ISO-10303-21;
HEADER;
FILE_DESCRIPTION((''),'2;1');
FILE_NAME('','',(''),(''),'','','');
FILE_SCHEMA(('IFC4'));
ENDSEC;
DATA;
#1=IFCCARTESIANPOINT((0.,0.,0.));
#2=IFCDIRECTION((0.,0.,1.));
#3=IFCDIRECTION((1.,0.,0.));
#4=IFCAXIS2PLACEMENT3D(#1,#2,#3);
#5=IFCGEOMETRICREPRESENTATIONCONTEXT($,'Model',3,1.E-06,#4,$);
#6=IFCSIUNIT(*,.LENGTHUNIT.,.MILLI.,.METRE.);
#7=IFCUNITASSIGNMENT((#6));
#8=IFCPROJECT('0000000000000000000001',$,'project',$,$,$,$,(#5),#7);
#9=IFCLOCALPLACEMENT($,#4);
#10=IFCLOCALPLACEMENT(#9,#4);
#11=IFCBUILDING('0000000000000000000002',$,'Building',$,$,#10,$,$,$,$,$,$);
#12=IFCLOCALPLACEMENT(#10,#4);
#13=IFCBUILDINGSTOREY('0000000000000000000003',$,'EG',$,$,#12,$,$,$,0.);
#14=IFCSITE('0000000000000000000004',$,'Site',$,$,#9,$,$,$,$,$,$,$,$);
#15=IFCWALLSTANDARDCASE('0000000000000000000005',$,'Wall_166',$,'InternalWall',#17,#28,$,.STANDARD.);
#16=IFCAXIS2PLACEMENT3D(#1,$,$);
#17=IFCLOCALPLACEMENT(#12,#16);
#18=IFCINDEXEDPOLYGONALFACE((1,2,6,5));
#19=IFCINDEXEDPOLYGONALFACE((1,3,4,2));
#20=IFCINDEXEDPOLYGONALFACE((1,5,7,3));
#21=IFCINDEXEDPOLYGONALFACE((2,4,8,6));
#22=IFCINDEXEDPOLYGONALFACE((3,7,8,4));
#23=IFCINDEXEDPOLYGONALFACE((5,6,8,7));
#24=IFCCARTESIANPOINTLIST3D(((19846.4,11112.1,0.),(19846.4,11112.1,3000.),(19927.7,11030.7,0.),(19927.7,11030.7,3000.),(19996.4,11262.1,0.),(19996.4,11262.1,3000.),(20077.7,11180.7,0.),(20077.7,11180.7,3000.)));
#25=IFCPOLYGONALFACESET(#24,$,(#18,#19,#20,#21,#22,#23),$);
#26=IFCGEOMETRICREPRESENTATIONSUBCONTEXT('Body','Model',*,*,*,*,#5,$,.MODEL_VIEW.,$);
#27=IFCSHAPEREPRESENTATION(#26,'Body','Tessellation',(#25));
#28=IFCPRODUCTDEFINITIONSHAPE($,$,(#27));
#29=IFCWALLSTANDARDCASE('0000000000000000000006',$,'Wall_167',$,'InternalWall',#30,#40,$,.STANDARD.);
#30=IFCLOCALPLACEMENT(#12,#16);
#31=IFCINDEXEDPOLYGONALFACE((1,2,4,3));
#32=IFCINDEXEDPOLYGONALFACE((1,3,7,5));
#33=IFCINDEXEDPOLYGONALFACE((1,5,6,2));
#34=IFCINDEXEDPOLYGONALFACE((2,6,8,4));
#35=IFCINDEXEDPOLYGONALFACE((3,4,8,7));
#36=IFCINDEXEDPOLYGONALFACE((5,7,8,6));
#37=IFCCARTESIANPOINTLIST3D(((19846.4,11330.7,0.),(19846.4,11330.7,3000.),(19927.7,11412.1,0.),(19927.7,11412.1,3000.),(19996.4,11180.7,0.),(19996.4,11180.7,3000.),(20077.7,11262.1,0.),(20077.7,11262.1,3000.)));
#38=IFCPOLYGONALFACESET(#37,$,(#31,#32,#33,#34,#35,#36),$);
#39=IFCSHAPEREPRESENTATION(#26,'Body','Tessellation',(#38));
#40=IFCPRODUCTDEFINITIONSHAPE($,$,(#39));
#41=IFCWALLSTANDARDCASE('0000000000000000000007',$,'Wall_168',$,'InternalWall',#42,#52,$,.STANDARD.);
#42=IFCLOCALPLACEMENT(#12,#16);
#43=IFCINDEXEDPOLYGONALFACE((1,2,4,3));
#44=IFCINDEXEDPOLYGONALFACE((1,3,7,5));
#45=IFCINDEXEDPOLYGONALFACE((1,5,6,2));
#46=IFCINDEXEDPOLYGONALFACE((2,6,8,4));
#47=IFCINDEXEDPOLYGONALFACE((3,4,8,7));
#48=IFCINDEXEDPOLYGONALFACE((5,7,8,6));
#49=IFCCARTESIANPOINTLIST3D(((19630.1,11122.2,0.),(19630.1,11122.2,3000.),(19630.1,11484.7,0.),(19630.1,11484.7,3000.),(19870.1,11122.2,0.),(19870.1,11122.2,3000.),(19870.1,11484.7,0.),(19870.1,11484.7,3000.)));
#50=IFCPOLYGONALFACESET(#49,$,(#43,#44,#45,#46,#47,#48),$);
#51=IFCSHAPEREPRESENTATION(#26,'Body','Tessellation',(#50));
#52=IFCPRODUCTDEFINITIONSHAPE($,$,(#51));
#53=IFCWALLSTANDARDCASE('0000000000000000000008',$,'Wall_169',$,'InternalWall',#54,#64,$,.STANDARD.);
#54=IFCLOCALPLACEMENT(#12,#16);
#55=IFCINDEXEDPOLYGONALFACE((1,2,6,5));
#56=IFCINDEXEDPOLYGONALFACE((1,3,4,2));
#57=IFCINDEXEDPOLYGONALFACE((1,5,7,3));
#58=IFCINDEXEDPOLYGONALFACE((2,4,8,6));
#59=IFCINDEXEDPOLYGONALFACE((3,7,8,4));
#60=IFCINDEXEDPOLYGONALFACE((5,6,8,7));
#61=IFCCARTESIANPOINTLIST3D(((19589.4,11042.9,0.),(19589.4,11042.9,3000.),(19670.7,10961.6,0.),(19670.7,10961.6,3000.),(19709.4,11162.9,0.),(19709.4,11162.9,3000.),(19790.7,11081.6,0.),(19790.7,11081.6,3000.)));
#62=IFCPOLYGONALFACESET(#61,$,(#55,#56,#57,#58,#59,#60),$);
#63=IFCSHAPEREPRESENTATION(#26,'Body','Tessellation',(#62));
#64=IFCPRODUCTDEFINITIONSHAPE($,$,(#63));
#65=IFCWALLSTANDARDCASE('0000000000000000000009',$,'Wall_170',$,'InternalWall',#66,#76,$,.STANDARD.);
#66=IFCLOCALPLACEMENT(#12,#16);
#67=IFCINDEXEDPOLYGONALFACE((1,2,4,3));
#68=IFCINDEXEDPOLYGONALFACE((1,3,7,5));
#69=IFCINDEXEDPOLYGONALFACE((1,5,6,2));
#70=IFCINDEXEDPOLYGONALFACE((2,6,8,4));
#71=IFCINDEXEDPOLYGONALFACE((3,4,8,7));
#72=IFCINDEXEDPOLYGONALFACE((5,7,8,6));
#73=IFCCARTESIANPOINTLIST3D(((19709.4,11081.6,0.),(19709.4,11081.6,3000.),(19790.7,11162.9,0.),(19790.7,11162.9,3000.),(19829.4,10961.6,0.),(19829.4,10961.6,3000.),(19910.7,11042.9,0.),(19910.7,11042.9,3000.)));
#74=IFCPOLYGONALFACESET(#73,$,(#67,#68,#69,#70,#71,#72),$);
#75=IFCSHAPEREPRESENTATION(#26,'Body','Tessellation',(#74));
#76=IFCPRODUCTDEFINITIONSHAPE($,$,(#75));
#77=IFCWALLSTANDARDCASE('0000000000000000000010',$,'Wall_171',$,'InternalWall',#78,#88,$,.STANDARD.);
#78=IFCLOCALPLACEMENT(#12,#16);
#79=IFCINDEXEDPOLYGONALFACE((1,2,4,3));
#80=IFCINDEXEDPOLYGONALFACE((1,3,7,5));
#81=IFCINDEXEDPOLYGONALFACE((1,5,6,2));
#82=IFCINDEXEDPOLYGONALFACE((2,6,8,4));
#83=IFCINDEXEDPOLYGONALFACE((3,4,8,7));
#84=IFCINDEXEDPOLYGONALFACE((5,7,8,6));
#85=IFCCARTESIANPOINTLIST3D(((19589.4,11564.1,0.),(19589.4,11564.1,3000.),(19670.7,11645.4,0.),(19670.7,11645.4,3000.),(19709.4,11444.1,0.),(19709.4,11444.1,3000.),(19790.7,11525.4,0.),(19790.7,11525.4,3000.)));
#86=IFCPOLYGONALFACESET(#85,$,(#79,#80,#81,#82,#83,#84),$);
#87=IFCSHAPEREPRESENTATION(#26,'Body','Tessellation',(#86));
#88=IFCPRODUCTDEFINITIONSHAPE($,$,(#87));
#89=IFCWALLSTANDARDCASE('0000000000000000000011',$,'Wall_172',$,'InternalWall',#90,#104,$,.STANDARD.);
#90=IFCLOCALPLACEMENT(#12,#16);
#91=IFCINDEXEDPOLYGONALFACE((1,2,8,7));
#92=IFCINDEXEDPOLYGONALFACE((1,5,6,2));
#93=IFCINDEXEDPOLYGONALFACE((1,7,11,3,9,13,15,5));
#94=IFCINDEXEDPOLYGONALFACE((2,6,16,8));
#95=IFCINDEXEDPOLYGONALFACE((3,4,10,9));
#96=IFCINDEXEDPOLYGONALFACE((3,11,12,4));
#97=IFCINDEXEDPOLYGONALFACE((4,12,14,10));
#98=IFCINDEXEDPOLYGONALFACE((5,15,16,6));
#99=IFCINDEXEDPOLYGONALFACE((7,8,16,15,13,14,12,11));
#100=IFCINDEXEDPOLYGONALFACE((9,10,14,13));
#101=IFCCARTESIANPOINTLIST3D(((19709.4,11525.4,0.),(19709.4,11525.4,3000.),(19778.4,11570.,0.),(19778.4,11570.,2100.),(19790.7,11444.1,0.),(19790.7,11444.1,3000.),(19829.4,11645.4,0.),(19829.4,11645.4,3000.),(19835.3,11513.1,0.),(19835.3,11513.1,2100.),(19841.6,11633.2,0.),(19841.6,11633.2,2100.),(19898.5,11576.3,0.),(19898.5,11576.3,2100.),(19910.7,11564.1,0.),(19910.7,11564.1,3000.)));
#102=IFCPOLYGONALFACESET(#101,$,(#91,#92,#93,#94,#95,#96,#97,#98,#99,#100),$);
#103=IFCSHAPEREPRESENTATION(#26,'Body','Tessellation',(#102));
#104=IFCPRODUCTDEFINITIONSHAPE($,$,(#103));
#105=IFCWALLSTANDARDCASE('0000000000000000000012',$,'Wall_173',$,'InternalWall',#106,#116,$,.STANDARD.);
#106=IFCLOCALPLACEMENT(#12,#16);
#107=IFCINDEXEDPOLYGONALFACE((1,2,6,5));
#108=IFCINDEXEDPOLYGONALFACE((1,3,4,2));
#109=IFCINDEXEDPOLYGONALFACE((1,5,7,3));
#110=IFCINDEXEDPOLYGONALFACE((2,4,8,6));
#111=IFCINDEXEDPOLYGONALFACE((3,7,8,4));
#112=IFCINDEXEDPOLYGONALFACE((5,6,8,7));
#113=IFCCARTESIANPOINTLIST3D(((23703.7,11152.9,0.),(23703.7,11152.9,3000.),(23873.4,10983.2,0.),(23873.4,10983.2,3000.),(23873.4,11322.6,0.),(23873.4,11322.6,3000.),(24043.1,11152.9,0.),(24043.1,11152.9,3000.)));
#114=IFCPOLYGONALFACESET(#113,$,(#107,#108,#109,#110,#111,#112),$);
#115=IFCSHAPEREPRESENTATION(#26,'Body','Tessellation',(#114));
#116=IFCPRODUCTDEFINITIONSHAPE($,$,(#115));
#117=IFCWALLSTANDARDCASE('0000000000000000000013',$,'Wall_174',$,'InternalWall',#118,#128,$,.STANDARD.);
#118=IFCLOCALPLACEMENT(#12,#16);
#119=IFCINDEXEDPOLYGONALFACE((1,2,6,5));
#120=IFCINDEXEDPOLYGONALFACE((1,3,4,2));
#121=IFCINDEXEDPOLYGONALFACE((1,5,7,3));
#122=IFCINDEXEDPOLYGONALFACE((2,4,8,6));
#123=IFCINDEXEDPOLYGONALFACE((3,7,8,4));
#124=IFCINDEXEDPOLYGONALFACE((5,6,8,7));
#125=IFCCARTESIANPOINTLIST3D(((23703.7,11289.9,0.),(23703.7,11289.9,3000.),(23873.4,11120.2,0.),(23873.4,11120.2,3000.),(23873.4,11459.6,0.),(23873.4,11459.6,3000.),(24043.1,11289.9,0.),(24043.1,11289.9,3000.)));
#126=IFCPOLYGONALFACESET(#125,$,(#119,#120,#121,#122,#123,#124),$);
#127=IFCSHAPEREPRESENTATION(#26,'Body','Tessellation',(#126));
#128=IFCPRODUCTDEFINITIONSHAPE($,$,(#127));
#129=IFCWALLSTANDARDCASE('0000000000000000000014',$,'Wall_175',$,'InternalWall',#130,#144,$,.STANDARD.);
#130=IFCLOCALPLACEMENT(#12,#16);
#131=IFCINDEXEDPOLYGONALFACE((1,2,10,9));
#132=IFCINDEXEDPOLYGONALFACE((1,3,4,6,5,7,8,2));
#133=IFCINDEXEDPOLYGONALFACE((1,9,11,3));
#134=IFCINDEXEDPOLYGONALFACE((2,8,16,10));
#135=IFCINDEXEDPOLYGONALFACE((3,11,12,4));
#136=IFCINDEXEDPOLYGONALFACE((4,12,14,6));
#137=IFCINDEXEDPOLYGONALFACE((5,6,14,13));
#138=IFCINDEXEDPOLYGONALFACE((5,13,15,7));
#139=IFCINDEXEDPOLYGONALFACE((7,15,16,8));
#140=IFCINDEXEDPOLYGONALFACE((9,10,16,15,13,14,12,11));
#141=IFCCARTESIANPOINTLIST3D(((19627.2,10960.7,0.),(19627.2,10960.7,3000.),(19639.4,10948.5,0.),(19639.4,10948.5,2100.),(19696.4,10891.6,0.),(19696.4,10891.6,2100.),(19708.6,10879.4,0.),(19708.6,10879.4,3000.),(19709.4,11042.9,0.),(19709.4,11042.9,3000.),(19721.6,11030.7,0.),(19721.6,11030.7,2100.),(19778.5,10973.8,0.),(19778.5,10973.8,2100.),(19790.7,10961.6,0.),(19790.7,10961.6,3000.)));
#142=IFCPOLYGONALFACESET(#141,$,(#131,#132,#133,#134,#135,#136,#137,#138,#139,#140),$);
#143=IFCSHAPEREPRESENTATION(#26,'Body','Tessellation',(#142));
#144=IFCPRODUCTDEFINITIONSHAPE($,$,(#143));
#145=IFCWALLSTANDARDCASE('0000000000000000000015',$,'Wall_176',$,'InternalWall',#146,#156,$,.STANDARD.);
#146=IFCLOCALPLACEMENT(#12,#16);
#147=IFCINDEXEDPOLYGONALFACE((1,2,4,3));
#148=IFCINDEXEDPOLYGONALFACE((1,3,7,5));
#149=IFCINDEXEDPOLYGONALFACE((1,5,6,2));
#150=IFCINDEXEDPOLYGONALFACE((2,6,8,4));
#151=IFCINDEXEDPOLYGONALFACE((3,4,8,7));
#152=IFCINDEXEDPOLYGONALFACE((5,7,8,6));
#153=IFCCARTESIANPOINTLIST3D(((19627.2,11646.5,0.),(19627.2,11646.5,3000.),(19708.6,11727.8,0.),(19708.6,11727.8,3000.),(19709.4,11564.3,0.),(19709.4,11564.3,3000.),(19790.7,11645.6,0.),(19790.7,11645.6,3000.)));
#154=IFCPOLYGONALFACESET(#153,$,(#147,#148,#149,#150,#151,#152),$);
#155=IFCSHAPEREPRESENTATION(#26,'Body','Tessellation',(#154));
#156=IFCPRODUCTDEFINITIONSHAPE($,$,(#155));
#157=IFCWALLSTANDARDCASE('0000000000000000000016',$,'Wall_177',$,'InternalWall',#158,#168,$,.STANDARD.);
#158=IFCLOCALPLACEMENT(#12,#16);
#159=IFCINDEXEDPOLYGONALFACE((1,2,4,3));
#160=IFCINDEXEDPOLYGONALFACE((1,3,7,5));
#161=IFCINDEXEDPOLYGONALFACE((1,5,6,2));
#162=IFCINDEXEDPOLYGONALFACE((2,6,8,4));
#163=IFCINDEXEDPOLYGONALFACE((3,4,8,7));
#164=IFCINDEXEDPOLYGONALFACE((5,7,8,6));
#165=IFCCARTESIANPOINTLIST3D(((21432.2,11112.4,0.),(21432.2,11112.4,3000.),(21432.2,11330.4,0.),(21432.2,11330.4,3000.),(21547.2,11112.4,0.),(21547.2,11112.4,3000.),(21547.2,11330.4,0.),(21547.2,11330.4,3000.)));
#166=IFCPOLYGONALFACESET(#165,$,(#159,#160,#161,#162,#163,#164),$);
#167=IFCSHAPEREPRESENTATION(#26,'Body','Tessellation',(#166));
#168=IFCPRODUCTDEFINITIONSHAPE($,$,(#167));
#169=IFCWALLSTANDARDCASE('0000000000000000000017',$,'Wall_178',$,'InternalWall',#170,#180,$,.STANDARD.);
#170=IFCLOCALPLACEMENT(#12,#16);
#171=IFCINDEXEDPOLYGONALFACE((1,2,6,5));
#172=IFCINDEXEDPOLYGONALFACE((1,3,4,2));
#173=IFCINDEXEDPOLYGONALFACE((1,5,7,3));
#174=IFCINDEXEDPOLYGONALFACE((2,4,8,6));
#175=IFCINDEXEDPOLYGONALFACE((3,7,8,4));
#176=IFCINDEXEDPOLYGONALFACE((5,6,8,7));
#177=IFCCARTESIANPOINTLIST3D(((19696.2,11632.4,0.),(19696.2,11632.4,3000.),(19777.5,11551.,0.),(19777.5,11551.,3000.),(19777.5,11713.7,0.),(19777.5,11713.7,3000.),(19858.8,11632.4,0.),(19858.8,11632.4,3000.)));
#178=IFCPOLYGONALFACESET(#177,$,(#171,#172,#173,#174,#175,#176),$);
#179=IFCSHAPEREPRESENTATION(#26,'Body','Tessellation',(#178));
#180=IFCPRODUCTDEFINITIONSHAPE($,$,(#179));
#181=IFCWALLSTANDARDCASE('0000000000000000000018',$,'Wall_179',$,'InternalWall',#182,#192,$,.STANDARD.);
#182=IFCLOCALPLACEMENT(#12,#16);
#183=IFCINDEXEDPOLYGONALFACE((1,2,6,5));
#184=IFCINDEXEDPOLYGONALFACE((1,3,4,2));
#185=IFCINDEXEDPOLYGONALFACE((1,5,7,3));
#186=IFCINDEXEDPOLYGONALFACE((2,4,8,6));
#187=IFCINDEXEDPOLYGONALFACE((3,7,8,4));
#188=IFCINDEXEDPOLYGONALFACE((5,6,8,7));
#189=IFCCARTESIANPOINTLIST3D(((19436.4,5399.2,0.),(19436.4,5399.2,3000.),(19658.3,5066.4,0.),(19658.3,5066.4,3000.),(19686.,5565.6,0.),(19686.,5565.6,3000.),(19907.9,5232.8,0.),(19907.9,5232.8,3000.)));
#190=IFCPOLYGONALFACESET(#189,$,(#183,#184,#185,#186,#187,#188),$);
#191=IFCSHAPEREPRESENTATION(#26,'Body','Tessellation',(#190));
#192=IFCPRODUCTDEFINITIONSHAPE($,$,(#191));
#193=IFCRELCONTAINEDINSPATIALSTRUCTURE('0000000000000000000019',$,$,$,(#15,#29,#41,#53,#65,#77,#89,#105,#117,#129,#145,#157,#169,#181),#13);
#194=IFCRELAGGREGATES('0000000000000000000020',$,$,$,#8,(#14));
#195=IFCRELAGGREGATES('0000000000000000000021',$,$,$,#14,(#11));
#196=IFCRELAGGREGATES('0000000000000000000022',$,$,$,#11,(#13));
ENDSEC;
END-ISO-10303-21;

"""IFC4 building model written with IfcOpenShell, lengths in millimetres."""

from ifc_helpers import new_model, si_unit, frame, origin_with_axes, place, context, subcontext, project, spatial, rectangle, extrude, element, save


model = new_model("IFC4")

# Units and contexts
model_context = context("Model", 3, precision=1e-06, world=origin_with_axes())
body_context = subcontext(model_context, "Body", "Model", "MODEL_VIEW")
ifc_project = project(units=[si_unit("LENGTHUNIT", "METRE", prefix="MILLI")], contexts=[model_context])

# Site, building, storey
site_placement = place(None, origin_with_axes())
site = spatial("IfcSite", under=ifc_project, at=site_placement, Name="Site")
building_placement = place(site_placement, origin_with_axes())
building = spatial("IfcBuilding", under=site, at=building_placement, Name="Building")
storey_placement = place(building_placement, origin_with_axes())
storey = spatial("IfcBuildingStorey", under=building, at=storey_placement, Name="EG", Elevation=0.0)

# Walls
wall_1_placement = place(storey_placement, origin_with_axes())
element("IfcWallStandardCase", 1, at=wall_1_placement, inside=storey, Name="Wall_166", ObjectType="InternalWall", PredefinedType="STANDARD", context=body_context, shape_type="SweptSolid", body=[
    extrude(rectangle(XDim=212.1, YDim=115.0), frame((19962.1, 11146.4, 0.0), z_axis=(0.0, 0.0, 1.0), x_axis=(-0.707107, -0.707107, 0.0)), (0.0, 0.0, 1.0), 3000.0),
])
wall_2_placement = place(storey_placement, origin_with_axes())
element("IfcWallStandardCase", 2, at=wall_2_placement, inside=storey, Name="Wall_167", ObjectType="InternalWall", PredefinedType="STANDARD", context=body_context, shape_type="SweptSolid", body=[
    extrude(rectangle(XDim=212.1, YDim=115.0), frame((19962.1, 11296.4, 0.0), z_axis=(0.0, 0.0, 1.0), x_axis=(-0.707107, 0.707107, 0.0)), (0.0, 0.0, 1.0), 3000.0),
])
wall_3_placement = place(storey_placement, origin_with_axes())
element("IfcWallStandardCase", 3, at=wall_3_placement, inside=storey, Name="Wall_168", ObjectType="InternalWall", PredefinedType="STANDARD", context=body_context, shape_type="SweptSolid", body=[
    extrude(rectangle(XDim=362.5, YDim=240.0), frame((19750.1, 11303.5, 0.0), z_axis=(0.0, 0.0, 1.0), x_axis=(0.0, 1.0, 0.0)), (0.0, 0.0, 1.0), 3000.0),
])
wall_4_placement = place(storey_placement, origin_with_axes())
element("IfcWallStandardCase", 4, at=wall_4_placement, inside=storey, Name="Wall_169", ObjectType="InternalWall", PredefinedType="STANDARD", context=body_context, shape_type="SweptSolid", body=[
    extrude(rectangle(XDim=169.7, YDim=115.0), frame((19690.1, 11062.2, 0.0), z_axis=(0.0, 0.0, 1.0), x_axis=(-0.707107, -0.707107, 0.0)), (0.0, 0.0, 1.0), 3000.0),
])
wall_5_placement = place(storey_placement, origin_with_axes())
element("IfcWallStandardCase", 5, at=wall_5_placement, inside=storey, Name="Wall_170", ObjectType="InternalWall", PredefinedType="STANDARD", context=body_context, shape_type="SweptSolid", body=[
    extrude(rectangle(XDim=169.7, YDim=115.0), frame((19810.1, 11062.2, 0.0), z_axis=(0.0, 0.0, 1.0), x_axis=(0.707107, -0.707107, 0.0)), (0.0, 0.0, 1.0), 3000.0),
])
wall_6_placement = place(storey_placement, origin_with_axes())
element("IfcWallStandardCase", 6, at=wall_6_placement, inside=storey, Name="Wall_171", ObjectType="InternalWall", PredefinedType="STANDARD", context=body_context, shape_type="SweptSolid", body=[
    extrude(rectangle(XDim=169.7, YDim=115.0), frame((19690.1, 11544.7, 0.0), z_axis=(0.0, 0.0, 1.0), x_axis=(-0.707107, 0.707107, 0.0)), (0.0, 0.0, 1.0), 3000.0),
])

# Wall, opening
wall_7_placement = place(storey_placement, origin_with_axes())
wall_7 = element("IfcWallStandardCase", 7, at=wall_7_placement, inside=storey, Name="Wall_172", ObjectType="InternalWall", PredefinedType="STANDARD", context=body_context, shape_type="SweptSolid", body=[
    extrude(rectangle(XDim=169.7, YDim=115.0), frame((19810.1, 11544.7, 0.0), z_axis=(0.0, 0.0, 1.0), x_axis=(0.707107, 0.707107, 0.0)), (0.0, 0.0, 1.0), 3000.0),
])
opening_1_placement = place(wall_7_placement, origin_with_axes())
element("IfcOpeningElement", 8, at=opening_1_placement, inside=storey, cuts=wall_7, context=body_context, shape_type="SweptSolid", body=[
    extrude(rectangle(XDim=886.7, YDim=80.5), frame((20120.4, 11855.0, 0.0), z_axis=(0.0, 0.0, 1.0), x_axis=(0.707107, 0.707107, 0.0)), (0.0, 0.0, 1.0), 2100.0),
])

# Walls
wall_8_placement = place(storey_placement, origin_with_axes())
element("IfcWallStandardCase", 9, at=wall_8_placement, inside=storey, Name="Wall_173", ObjectType="InternalWall", PredefinedType="STANDARD", context=body_context, shape_type="SweptSolid", body=[
    extrude(rectangle(XDim=240.0, YDim=240.0), frame((23873.4, 11152.9, 0.0), z_axis=(0.0, 0.0, 1.0), x_axis=(-0.707107, -0.707107, 0.0)), (0.0, 0.0, 1.0), 3000.0),
])
wall_9_placement = place(storey_placement, origin_with_axes())
element("IfcWallStandardCase", 10, at=wall_9_placement, inside=storey, Name="Wall_174", ObjectType="InternalWall", PredefinedType="STANDARD", context=body_context, shape_type="SweptSolid", body=[
    extrude(rectangle(XDim=240.0, YDim=240.0), frame((23873.4, 11289.9, 0.0), z_axis=(0.0, 0.0, 1.0), x_axis=(-0.707107, 0.707107, 0.0)), (0.0, 0.0, 1.0), 3000.0),
])

# Wall, opening
wall_10_placement = place(storey_placement, origin_with_axes())
wall_10 = element("IfcWallStandardCase", 11, at=wall_10_placement, inside=storey, Name="Wall_175", ObjectType="InternalWall", PredefinedType="STANDARD", context=body_context, shape_type="SweptSolid", body=[
    extrude(rectangle(XDim=116.2, YDim=115.0), frame((19709.0, 10961.1, 0.0), z_axis=(0.0, 0.0, 1.0), x_axis=(-0.707107, -0.707107, 0.0)), (0.0, 0.0, 1.0), 3000.0),
])
opening_2_placement = place(wall_10_placement, origin_with_axes())
element("IfcOpeningElement", 12, at=opening_2_placement, inside=storey, cuts=wall_10, context=body_context, shape_type="SweptSolid", body=[
    extrude(rectangle(XDim=1483.8, YDim=80.5), frame((19689.2, 10941.4, 0.0), z_axis=(0.0, 0.0, 1.0), x_axis=(-0.707107, -0.707107, 0.0)), (0.0, 0.0, 1.0), 2100.0),
])

# Walls
wall_11_placement = place(storey_placement, origin_with_axes())
element("IfcWallStandardCase", 13, at=wall_11_placement, inside=storey, Name="Wall_176", ObjectType="InternalWall", PredefinedType="STANDARD", context=body_context, shape_type="SweptSolid", body=[
    extrude(rectangle(XDim=116.2, YDim=115.0), frame((19709.0, 11646.1, 0.0), z_axis=(0.0, 0.0, 1.0), x_axis=(0.707107, -0.707107, 0.0)), (0.0, 0.0, 1.0), 3000.0),
])
wall_12_placement = place(storey_placement, origin_with_axes())
element("IfcWallStandardCase", 14, at=wall_12_placement, inside=storey, Name="Wall_177", ObjectType="InternalWall", PredefinedType="STANDARD", context=body_context, shape_type="SweptSolid", body=[
    extrude(rectangle(XDim=218.0, YDim=115.0), frame((21489.7, 11221.4, 0.0), z_axis=(0.0, 0.0, 1.0), x_axis=(0.0, -1.0, 0.0)), (0.0, 0.0, 1.0), 3000.0),
])
wall_13_placement = place(storey_placement, origin_with_axes())
element("IfcWallStandardCase", 15, at=wall_13_placement, inside=storey, Name="Wall_178", ObjectType="InternalWall", PredefinedType="STANDARD", context=body_context, shape_type="SweptSolid", body=[
    extrude(rectangle(XDim=115.0, YDim=115.0), frame((19777.5, 11632.4, 0.0), z_axis=(0.0, 0.0, 1.0), x_axis=(-0.707107, 0.707107, 0.0)), (0.0, 0.0, 1.0), 3000.0),
])
wall_14_placement = place(storey_placement, origin_with_axes())
element("IfcWallStandardCase", 16, at=wall_14_placement, inside=storey, Name="Wall_179", ObjectType="InternalWall", PredefinedType="STANDARD", context=body_context, shape_type="SweptSolid", body=[
    extrude(rectangle(XDim=400.0, YDim=300.0), frame((19672.2, 5316.0, 0.0), z_axis=(0.0, 0.0, 1.0), x_axis=(-0.5547, 0.83205, 0.0)), (0.0, 0.0, 1.0), 3000.0),
])

save(model, "model.ifc")
